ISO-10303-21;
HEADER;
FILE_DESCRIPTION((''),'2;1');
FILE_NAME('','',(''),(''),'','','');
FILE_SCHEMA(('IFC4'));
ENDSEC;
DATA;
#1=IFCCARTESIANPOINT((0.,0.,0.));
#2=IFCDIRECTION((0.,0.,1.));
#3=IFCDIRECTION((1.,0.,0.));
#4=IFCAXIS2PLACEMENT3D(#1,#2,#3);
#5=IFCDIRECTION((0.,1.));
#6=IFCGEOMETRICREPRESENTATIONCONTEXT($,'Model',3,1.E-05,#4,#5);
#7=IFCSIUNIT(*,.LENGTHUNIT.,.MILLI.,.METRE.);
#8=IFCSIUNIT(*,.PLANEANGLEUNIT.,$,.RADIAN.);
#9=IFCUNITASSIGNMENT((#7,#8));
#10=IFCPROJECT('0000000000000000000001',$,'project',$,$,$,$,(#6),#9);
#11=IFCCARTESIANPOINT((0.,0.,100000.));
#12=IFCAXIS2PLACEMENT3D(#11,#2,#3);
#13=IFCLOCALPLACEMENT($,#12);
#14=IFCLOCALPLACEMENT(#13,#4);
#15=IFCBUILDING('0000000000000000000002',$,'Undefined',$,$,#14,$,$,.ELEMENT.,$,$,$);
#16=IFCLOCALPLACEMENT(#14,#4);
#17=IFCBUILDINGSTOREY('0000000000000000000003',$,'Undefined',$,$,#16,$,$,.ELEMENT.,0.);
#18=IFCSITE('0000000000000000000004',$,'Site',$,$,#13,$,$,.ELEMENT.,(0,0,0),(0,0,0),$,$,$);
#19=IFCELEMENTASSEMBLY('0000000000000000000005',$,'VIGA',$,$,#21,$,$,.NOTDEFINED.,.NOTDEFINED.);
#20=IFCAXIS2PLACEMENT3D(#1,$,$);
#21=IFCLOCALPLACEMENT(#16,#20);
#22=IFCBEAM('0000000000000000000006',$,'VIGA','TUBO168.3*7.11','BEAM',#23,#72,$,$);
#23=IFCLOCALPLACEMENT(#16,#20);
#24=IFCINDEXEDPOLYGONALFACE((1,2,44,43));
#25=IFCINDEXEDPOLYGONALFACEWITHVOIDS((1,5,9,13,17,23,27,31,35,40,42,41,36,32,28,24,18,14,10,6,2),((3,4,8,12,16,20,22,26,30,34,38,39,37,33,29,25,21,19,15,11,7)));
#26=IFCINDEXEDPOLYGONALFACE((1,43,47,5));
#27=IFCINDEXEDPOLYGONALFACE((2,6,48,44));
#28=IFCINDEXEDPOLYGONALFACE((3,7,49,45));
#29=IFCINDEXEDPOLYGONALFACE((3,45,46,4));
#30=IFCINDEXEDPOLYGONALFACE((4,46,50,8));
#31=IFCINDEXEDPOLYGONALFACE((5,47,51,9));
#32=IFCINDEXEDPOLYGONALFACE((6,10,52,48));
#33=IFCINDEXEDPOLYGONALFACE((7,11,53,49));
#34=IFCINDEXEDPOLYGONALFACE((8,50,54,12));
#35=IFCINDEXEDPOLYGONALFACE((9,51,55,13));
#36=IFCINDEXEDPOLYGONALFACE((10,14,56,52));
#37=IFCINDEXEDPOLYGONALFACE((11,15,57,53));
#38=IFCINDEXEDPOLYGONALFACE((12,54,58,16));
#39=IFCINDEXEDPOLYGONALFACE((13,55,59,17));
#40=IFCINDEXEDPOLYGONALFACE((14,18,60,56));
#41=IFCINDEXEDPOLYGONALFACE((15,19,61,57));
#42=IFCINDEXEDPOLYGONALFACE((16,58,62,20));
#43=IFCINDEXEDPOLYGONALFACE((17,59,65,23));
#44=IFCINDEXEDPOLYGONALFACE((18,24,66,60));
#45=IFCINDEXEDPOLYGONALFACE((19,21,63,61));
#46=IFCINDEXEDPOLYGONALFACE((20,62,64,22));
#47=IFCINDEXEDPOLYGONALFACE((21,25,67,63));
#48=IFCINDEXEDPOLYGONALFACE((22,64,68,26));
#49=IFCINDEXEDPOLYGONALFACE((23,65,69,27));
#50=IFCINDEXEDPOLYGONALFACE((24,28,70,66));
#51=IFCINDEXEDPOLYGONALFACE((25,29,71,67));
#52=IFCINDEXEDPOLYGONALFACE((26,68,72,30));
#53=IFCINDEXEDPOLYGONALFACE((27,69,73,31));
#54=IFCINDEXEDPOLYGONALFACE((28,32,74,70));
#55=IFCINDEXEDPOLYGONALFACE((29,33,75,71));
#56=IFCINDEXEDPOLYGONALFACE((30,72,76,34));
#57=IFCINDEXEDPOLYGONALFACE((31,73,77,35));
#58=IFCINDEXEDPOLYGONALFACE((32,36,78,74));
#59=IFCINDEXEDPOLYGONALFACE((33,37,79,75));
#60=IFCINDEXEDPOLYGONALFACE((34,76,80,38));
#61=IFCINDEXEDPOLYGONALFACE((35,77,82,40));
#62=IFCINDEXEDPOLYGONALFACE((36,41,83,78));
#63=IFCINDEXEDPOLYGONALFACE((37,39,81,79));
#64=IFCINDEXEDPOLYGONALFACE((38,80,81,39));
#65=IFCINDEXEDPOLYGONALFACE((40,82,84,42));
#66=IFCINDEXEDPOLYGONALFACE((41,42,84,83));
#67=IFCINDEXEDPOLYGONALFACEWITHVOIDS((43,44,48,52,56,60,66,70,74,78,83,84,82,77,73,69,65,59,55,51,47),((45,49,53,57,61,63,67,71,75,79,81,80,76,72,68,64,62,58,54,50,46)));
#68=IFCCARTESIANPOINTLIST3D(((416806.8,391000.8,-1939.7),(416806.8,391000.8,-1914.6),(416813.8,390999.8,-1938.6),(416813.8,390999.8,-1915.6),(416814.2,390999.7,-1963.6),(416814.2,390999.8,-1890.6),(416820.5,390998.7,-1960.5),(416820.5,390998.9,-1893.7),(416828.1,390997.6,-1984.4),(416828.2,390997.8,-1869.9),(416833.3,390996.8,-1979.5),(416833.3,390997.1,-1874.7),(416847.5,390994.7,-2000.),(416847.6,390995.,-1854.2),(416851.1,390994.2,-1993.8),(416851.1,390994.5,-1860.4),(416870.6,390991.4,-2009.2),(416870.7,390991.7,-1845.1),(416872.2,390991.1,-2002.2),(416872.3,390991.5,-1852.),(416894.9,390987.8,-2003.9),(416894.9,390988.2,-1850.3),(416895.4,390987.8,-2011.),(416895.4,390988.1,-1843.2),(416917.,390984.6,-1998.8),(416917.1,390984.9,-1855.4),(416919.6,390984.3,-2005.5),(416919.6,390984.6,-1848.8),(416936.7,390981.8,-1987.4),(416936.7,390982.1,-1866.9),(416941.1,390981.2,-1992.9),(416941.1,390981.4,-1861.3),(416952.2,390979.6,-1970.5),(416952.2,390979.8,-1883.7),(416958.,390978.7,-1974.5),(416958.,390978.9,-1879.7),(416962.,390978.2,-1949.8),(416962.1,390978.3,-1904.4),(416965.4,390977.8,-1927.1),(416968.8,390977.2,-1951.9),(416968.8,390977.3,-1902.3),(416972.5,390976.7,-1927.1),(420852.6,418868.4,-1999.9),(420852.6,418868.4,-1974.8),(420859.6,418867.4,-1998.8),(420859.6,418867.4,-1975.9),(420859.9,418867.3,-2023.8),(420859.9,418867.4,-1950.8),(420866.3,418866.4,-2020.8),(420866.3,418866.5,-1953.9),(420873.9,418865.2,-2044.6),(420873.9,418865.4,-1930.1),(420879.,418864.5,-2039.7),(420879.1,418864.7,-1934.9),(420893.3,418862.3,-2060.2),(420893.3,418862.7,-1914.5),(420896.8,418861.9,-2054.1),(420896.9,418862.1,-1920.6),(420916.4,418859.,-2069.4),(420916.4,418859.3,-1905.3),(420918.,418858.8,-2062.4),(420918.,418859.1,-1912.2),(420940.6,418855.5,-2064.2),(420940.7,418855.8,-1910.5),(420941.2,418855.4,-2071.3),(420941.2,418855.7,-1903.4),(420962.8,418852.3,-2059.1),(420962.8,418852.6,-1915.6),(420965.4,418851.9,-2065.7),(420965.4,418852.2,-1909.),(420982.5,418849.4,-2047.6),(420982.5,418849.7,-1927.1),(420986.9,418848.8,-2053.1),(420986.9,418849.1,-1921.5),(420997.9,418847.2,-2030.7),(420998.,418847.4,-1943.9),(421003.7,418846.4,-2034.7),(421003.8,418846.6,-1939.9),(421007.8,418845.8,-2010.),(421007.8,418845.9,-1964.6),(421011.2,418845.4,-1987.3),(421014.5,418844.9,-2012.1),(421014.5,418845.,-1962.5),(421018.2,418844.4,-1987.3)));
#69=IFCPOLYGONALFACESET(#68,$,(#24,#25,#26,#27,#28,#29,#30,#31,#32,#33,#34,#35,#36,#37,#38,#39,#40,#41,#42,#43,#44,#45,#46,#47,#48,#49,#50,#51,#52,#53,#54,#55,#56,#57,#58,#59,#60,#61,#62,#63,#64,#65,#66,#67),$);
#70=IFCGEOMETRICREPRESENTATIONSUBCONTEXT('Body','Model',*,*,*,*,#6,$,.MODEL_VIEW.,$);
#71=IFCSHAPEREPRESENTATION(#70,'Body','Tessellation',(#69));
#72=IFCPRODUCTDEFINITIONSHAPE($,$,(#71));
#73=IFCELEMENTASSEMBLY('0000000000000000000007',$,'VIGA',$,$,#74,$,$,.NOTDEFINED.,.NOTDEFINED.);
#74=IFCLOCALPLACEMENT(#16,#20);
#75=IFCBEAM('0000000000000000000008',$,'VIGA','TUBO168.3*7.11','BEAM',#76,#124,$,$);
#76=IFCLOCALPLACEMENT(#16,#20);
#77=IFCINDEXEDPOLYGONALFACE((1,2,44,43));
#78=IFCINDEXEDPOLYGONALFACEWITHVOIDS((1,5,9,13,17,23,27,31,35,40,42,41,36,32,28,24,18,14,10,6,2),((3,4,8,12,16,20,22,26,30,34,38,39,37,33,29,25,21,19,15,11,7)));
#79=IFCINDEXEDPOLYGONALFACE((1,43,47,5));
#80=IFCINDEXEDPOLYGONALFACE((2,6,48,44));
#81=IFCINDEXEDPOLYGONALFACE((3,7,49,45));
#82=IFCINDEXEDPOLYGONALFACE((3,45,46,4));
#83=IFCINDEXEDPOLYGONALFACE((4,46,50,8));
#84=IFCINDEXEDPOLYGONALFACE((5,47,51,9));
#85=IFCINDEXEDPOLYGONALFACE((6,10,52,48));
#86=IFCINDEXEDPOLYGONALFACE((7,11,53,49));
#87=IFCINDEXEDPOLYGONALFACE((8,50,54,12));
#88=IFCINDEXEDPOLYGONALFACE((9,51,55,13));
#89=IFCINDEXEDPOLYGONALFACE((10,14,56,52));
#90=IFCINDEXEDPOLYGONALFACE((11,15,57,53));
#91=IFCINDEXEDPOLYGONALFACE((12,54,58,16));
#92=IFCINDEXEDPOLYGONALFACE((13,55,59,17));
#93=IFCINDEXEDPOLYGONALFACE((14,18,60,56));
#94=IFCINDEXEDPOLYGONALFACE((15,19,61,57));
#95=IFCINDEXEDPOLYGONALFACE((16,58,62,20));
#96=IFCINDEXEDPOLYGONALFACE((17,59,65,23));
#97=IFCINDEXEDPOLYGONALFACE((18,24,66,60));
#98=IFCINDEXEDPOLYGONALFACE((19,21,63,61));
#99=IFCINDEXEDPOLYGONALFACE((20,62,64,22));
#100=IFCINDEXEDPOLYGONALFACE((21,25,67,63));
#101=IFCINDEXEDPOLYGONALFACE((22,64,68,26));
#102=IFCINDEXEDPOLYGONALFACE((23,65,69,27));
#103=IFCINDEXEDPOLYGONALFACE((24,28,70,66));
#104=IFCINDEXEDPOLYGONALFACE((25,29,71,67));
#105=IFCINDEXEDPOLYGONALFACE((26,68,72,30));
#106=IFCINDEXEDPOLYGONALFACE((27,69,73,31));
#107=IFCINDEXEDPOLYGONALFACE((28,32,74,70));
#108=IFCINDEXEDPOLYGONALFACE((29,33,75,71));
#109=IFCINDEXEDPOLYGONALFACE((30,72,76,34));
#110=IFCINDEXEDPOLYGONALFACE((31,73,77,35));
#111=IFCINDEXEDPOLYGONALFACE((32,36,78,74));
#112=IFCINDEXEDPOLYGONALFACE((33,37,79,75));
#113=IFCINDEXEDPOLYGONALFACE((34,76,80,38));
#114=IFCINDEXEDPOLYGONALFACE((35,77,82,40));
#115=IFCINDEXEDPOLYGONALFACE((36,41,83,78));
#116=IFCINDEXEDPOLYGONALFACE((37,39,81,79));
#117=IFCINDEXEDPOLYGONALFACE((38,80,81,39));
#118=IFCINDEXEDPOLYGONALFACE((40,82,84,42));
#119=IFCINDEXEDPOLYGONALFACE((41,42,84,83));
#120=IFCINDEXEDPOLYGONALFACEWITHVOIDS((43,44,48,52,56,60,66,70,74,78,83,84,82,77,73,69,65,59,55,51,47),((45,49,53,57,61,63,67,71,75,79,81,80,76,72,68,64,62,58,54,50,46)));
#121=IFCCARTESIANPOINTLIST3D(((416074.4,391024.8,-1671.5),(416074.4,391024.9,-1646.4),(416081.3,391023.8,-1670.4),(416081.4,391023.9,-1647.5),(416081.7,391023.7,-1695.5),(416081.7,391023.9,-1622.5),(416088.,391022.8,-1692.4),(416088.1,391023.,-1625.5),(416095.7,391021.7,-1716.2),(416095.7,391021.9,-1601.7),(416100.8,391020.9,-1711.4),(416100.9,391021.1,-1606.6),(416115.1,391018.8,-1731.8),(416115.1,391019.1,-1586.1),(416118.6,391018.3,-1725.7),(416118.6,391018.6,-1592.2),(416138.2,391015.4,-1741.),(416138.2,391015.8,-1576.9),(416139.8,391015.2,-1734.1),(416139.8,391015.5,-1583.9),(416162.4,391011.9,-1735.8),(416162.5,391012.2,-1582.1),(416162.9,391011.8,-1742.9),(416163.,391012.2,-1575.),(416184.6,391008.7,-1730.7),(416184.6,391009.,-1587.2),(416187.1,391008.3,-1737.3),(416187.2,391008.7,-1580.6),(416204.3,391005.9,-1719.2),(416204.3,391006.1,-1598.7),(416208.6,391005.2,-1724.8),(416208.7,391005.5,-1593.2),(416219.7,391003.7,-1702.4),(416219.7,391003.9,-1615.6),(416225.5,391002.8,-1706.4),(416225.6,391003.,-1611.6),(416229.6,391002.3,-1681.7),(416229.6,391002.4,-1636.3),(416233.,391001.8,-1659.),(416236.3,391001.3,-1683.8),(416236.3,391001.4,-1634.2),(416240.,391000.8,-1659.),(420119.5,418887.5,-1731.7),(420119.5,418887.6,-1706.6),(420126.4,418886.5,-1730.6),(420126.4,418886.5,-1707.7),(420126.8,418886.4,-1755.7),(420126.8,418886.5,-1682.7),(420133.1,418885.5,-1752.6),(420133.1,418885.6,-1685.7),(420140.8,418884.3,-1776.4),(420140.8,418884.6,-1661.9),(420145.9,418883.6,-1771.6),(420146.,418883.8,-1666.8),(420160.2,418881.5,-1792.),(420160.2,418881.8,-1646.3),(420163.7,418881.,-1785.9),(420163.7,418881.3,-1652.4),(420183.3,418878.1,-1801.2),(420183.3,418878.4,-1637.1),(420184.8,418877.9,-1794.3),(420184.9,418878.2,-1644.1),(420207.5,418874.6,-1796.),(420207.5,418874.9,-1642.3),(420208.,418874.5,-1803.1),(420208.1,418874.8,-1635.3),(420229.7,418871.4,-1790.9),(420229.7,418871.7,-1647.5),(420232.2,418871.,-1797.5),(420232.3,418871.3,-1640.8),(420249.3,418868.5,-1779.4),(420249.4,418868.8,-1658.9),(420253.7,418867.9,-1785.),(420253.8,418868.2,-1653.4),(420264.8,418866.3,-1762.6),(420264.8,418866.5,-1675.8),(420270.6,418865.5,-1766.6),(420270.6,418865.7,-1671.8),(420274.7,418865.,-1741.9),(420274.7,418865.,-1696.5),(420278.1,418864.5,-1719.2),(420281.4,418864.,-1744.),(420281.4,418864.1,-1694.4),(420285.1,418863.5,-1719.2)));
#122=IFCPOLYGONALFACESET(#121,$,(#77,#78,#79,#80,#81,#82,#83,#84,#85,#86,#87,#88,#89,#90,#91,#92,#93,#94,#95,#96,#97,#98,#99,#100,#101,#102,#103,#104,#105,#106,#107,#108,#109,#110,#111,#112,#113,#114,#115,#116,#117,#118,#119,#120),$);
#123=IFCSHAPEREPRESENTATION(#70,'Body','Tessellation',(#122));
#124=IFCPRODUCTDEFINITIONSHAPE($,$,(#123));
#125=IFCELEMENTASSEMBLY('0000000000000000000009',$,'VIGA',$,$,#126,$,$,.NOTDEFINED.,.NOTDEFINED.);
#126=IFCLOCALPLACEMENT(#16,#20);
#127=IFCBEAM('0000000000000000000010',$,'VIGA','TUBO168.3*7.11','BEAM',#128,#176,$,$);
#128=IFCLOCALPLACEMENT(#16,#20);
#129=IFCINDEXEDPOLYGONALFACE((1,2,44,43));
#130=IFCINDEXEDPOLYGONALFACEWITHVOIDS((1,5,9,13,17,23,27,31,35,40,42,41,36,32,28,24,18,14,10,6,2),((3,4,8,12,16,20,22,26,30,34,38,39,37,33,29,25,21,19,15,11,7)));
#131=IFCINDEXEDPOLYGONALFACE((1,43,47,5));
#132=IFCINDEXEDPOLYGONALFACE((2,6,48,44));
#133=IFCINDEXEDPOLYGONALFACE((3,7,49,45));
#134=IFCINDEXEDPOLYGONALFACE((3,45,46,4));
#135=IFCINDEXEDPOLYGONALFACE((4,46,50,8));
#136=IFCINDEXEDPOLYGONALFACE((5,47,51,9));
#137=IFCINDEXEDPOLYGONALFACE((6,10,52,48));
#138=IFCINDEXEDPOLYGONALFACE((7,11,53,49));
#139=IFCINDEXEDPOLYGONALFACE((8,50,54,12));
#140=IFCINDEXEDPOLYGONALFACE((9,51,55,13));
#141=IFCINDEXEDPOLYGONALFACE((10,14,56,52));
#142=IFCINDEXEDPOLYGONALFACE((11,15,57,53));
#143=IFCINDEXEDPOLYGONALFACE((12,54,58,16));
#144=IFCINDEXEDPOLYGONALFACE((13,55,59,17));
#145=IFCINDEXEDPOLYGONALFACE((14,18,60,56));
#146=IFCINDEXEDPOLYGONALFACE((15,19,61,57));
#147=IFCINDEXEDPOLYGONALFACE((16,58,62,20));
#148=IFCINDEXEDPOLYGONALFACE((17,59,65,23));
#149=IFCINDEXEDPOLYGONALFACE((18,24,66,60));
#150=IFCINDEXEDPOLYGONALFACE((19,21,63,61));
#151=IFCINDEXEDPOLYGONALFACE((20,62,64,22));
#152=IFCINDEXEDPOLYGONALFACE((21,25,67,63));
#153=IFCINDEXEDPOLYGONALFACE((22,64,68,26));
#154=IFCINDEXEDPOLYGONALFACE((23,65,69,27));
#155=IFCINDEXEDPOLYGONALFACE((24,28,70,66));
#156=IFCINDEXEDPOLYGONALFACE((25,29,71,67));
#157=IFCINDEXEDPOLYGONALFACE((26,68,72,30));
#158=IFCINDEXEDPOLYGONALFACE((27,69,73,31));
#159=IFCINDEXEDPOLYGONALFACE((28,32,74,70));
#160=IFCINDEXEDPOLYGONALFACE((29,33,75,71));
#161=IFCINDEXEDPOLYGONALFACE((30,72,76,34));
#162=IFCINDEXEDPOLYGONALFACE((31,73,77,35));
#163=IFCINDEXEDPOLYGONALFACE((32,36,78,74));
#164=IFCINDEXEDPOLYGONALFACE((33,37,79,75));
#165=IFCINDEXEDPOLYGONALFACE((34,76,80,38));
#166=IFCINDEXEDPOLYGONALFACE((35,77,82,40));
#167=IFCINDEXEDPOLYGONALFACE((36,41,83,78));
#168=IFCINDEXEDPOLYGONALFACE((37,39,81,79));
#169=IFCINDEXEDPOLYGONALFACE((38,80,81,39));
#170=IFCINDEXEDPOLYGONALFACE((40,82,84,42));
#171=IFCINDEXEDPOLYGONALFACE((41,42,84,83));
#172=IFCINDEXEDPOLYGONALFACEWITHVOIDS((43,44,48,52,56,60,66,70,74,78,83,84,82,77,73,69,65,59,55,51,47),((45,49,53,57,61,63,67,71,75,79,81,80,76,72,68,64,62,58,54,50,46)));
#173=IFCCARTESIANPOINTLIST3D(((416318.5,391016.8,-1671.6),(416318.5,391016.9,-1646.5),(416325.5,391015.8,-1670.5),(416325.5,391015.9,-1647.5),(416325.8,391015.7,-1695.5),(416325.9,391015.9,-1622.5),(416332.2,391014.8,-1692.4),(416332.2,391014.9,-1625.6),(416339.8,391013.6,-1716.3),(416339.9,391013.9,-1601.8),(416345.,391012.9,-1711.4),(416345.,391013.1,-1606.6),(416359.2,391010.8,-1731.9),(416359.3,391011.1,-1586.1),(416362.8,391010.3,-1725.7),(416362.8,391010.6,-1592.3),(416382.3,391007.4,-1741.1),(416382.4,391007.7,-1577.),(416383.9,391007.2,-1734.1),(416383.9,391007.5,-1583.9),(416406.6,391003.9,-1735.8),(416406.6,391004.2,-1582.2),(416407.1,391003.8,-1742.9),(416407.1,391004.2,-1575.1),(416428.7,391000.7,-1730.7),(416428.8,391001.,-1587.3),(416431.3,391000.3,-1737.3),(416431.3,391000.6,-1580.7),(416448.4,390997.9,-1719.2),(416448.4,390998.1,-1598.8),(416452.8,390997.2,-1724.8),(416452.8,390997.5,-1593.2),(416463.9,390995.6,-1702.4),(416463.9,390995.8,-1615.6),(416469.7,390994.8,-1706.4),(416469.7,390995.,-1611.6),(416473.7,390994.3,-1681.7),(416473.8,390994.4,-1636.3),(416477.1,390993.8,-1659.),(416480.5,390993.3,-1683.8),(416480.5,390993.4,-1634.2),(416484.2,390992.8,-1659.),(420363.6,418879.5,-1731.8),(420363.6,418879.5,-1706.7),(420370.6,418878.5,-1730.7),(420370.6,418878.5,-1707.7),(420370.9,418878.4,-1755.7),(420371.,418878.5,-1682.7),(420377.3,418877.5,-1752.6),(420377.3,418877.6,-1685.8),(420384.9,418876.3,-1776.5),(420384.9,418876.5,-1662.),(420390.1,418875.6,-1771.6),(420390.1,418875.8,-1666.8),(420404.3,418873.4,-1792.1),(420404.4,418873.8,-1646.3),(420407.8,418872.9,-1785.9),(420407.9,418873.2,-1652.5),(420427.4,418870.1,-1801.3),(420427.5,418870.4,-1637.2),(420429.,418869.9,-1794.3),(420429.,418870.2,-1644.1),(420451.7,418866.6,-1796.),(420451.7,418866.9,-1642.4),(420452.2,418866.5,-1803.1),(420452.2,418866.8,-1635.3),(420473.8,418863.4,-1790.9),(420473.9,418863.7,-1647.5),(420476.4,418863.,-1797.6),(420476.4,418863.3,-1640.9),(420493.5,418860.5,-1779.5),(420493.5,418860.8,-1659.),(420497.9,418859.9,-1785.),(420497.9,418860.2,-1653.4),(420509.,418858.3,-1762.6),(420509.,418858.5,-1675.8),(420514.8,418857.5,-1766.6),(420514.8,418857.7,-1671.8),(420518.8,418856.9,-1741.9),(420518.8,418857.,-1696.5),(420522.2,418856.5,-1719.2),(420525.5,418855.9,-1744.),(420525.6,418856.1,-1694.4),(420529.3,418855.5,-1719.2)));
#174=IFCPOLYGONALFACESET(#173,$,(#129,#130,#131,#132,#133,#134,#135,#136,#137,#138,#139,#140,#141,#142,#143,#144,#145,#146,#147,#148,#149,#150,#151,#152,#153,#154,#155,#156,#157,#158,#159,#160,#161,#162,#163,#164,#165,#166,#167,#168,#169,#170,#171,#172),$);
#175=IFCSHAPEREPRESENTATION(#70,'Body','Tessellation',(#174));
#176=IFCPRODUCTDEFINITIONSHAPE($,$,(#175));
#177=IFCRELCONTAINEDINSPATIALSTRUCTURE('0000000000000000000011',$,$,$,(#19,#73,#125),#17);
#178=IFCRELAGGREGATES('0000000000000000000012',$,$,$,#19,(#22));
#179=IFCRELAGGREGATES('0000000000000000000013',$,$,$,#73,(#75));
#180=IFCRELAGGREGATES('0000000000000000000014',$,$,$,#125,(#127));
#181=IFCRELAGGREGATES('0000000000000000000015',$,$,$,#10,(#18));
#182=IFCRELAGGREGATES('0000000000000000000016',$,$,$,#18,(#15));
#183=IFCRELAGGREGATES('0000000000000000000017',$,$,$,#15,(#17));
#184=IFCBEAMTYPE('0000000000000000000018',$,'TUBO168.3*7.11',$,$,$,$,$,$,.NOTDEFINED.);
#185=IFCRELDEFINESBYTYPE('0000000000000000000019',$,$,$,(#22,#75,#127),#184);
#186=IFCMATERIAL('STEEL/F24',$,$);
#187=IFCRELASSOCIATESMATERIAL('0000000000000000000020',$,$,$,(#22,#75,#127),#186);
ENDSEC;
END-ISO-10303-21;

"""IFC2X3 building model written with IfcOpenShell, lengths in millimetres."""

from ifc_helpers import new_model, si_unit, direction, frame, origin_with_axes, origin_2d_with_axis, place, context, subcontext, project, spatial, hollow_circle, extrude, material, type_object, element, aggregate, save


model = new_model("IFC2X3")

# Units and contexts
model_context = context("Model", 3, precision=1e-05, world=origin_with_axes(), true_north=direction((0.0, 1.0)))
body_context = subcontext(model_context, "Body", "Model", "MODEL_VIEW")
ifc_project = project(units=[si_unit("LENGTHUNIT", "METRE", prefix="MILLI"), si_unit("PLANEANGLEUNIT", "RADIAN")], contexts=[model_context])

# Site, building, storey
site_placement = place(None, frame((0.0, 0.0, 100000.0), z_axis=(0.0, 0.0, 1.0), x_axis=(1.0, 0.0, 0.0)))
site = spatial("IfcSite", under=ifc_project, at=site_placement, Name="Site", CompositionType="ELEMENT", RefLatitude=(0, 0, 0), RefLongitude=(0, 0, 0))
building_placement = place(site_placement, origin_with_axes())
building = spatial("IfcBuilding", under=site, at=building_placement, Name="Undefined", CompositionType="ELEMENT")
storey_placement = place(building_placement, origin_with_axes())
storey = spatial("IfcBuildingStorey", under=building, at=storey_placement, Name="Undefined", CompositionType="ELEMENT", Elevation=0.0)

# Element assemblies, beams
ifc_material_1 = material(Name="STEEL/F24")
beam_type_1 = type_object("IfcBeamType", Name="TUBO168.3*7.11", PredefinedType="NOTDEFINED")
assembly_1_placement = place(storey_placement, origin_with_axes())
assembly_1 = element("IfcElementAssembly", 1, at=assembly_1_placement, inside=storey, Name="VIGA", AssemblyPlace="NOTDEFINED", PredefinedType="NOTDEFINED")
beam_1_placement = place(assembly_1_placement, frame((416889.2, 390988.8, -1927.1), z_axis=(0.000307, 0.002116, 0.999998), x_axis=(0.143671, 0.989623, -0.002138)))
beam_1 = element("IfcBeam", 2, at=beam_1_placement, type_object=beam_type_1, material=ifc_material_1, Name="VIGA", Description="TUBO168.3*7.11", ObjectType="BEAM", context=body_context, shape_type="SweptSolid", body=[
    extrude(hollow_circle(Radius=84.2, WallThickness=7.1, at=origin_2d_with_axis()), frame((28159.8, 0.0, 0.0), z_axis=(-1.0, 0.0, 0.0), x_axis=(0.0, -1.0, 0.0)), (0.0, 0.0, 1.0), 28159.8),
])
aggregate(assembly_1, [beam_1])
assembly_2_placement = place(storey_placement, origin_with_axes())
assembly_2 = element("IfcElementAssembly", 3, at=assembly_2_placement, inside=storey, Name="VIGA", AssemblyPlace="NOTDEFINED", PredefinedType="NOTDEFINED")
beam_2_placement = place(assembly_2_placement, frame((416156.7, 391012.9, -1659.0), z_axis=(0.000307, 0.002116, 0.999998), x_axis=(0.143673, 0.989623, -0.002138)))
beam_2 = element("IfcBeam", 4, at=beam_2_placement, type_object=beam_type_1, material=ifc_material_1, Name="VIGA", Description="TUBO168.3*7.11", ObjectType="BEAM", context=body_context, shape_type="SweptSolid", body=[
    extrude(hollow_circle(Radius=84.2, WallThickness=7.1, at=origin_2d_with_axis()), frame((28154.8, 0.0, 0.0), z_axis=(-1.0, 0.0, 0.0), x_axis=(0.0, -1.0, 0.0)), (0.0, 0.0, 1.0), 28154.8),
])
aggregate(assembly_2, [beam_2])
assembly_3_placement = place(storey_placement, origin_with_axes())
assembly_3 = element("IfcElementAssembly", 5, at=assembly_3_placement, inside=storey, Name="VIGA", AssemblyPlace="NOTDEFINED", PredefinedType="NOTDEFINED")
beam_3_placement = place(assembly_3_placement, frame((416400.9, 391004.9, -1659.0), z_axis=(0.000307, 0.002116, 0.999998), x_axis=(0.143673, 0.989623, -0.002138)))
beam_3 = element("IfcBeam", 6, at=beam_3_placement, type_object=beam_type_1, material=ifc_material_1, Name="VIGA", Description="TUBO168.3*7.11", ObjectType="BEAM", context=body_context, shape_type="SweptSolid", body=[
    extrude(hollow_circle(Radius=84.2, WallThickness=7.1, at=origin_2d_with_axis()), frame((28154.8, 0.0, 0.0), z_axis=(-1.0, 0.0, 0.0), x_axis=(0.0, -1.0, 0.0)), (0.0, 0.0, 1.0), 28154.8),
])
aggregate(assembly_3, [beam_3])

save(model, "model.ifc")
